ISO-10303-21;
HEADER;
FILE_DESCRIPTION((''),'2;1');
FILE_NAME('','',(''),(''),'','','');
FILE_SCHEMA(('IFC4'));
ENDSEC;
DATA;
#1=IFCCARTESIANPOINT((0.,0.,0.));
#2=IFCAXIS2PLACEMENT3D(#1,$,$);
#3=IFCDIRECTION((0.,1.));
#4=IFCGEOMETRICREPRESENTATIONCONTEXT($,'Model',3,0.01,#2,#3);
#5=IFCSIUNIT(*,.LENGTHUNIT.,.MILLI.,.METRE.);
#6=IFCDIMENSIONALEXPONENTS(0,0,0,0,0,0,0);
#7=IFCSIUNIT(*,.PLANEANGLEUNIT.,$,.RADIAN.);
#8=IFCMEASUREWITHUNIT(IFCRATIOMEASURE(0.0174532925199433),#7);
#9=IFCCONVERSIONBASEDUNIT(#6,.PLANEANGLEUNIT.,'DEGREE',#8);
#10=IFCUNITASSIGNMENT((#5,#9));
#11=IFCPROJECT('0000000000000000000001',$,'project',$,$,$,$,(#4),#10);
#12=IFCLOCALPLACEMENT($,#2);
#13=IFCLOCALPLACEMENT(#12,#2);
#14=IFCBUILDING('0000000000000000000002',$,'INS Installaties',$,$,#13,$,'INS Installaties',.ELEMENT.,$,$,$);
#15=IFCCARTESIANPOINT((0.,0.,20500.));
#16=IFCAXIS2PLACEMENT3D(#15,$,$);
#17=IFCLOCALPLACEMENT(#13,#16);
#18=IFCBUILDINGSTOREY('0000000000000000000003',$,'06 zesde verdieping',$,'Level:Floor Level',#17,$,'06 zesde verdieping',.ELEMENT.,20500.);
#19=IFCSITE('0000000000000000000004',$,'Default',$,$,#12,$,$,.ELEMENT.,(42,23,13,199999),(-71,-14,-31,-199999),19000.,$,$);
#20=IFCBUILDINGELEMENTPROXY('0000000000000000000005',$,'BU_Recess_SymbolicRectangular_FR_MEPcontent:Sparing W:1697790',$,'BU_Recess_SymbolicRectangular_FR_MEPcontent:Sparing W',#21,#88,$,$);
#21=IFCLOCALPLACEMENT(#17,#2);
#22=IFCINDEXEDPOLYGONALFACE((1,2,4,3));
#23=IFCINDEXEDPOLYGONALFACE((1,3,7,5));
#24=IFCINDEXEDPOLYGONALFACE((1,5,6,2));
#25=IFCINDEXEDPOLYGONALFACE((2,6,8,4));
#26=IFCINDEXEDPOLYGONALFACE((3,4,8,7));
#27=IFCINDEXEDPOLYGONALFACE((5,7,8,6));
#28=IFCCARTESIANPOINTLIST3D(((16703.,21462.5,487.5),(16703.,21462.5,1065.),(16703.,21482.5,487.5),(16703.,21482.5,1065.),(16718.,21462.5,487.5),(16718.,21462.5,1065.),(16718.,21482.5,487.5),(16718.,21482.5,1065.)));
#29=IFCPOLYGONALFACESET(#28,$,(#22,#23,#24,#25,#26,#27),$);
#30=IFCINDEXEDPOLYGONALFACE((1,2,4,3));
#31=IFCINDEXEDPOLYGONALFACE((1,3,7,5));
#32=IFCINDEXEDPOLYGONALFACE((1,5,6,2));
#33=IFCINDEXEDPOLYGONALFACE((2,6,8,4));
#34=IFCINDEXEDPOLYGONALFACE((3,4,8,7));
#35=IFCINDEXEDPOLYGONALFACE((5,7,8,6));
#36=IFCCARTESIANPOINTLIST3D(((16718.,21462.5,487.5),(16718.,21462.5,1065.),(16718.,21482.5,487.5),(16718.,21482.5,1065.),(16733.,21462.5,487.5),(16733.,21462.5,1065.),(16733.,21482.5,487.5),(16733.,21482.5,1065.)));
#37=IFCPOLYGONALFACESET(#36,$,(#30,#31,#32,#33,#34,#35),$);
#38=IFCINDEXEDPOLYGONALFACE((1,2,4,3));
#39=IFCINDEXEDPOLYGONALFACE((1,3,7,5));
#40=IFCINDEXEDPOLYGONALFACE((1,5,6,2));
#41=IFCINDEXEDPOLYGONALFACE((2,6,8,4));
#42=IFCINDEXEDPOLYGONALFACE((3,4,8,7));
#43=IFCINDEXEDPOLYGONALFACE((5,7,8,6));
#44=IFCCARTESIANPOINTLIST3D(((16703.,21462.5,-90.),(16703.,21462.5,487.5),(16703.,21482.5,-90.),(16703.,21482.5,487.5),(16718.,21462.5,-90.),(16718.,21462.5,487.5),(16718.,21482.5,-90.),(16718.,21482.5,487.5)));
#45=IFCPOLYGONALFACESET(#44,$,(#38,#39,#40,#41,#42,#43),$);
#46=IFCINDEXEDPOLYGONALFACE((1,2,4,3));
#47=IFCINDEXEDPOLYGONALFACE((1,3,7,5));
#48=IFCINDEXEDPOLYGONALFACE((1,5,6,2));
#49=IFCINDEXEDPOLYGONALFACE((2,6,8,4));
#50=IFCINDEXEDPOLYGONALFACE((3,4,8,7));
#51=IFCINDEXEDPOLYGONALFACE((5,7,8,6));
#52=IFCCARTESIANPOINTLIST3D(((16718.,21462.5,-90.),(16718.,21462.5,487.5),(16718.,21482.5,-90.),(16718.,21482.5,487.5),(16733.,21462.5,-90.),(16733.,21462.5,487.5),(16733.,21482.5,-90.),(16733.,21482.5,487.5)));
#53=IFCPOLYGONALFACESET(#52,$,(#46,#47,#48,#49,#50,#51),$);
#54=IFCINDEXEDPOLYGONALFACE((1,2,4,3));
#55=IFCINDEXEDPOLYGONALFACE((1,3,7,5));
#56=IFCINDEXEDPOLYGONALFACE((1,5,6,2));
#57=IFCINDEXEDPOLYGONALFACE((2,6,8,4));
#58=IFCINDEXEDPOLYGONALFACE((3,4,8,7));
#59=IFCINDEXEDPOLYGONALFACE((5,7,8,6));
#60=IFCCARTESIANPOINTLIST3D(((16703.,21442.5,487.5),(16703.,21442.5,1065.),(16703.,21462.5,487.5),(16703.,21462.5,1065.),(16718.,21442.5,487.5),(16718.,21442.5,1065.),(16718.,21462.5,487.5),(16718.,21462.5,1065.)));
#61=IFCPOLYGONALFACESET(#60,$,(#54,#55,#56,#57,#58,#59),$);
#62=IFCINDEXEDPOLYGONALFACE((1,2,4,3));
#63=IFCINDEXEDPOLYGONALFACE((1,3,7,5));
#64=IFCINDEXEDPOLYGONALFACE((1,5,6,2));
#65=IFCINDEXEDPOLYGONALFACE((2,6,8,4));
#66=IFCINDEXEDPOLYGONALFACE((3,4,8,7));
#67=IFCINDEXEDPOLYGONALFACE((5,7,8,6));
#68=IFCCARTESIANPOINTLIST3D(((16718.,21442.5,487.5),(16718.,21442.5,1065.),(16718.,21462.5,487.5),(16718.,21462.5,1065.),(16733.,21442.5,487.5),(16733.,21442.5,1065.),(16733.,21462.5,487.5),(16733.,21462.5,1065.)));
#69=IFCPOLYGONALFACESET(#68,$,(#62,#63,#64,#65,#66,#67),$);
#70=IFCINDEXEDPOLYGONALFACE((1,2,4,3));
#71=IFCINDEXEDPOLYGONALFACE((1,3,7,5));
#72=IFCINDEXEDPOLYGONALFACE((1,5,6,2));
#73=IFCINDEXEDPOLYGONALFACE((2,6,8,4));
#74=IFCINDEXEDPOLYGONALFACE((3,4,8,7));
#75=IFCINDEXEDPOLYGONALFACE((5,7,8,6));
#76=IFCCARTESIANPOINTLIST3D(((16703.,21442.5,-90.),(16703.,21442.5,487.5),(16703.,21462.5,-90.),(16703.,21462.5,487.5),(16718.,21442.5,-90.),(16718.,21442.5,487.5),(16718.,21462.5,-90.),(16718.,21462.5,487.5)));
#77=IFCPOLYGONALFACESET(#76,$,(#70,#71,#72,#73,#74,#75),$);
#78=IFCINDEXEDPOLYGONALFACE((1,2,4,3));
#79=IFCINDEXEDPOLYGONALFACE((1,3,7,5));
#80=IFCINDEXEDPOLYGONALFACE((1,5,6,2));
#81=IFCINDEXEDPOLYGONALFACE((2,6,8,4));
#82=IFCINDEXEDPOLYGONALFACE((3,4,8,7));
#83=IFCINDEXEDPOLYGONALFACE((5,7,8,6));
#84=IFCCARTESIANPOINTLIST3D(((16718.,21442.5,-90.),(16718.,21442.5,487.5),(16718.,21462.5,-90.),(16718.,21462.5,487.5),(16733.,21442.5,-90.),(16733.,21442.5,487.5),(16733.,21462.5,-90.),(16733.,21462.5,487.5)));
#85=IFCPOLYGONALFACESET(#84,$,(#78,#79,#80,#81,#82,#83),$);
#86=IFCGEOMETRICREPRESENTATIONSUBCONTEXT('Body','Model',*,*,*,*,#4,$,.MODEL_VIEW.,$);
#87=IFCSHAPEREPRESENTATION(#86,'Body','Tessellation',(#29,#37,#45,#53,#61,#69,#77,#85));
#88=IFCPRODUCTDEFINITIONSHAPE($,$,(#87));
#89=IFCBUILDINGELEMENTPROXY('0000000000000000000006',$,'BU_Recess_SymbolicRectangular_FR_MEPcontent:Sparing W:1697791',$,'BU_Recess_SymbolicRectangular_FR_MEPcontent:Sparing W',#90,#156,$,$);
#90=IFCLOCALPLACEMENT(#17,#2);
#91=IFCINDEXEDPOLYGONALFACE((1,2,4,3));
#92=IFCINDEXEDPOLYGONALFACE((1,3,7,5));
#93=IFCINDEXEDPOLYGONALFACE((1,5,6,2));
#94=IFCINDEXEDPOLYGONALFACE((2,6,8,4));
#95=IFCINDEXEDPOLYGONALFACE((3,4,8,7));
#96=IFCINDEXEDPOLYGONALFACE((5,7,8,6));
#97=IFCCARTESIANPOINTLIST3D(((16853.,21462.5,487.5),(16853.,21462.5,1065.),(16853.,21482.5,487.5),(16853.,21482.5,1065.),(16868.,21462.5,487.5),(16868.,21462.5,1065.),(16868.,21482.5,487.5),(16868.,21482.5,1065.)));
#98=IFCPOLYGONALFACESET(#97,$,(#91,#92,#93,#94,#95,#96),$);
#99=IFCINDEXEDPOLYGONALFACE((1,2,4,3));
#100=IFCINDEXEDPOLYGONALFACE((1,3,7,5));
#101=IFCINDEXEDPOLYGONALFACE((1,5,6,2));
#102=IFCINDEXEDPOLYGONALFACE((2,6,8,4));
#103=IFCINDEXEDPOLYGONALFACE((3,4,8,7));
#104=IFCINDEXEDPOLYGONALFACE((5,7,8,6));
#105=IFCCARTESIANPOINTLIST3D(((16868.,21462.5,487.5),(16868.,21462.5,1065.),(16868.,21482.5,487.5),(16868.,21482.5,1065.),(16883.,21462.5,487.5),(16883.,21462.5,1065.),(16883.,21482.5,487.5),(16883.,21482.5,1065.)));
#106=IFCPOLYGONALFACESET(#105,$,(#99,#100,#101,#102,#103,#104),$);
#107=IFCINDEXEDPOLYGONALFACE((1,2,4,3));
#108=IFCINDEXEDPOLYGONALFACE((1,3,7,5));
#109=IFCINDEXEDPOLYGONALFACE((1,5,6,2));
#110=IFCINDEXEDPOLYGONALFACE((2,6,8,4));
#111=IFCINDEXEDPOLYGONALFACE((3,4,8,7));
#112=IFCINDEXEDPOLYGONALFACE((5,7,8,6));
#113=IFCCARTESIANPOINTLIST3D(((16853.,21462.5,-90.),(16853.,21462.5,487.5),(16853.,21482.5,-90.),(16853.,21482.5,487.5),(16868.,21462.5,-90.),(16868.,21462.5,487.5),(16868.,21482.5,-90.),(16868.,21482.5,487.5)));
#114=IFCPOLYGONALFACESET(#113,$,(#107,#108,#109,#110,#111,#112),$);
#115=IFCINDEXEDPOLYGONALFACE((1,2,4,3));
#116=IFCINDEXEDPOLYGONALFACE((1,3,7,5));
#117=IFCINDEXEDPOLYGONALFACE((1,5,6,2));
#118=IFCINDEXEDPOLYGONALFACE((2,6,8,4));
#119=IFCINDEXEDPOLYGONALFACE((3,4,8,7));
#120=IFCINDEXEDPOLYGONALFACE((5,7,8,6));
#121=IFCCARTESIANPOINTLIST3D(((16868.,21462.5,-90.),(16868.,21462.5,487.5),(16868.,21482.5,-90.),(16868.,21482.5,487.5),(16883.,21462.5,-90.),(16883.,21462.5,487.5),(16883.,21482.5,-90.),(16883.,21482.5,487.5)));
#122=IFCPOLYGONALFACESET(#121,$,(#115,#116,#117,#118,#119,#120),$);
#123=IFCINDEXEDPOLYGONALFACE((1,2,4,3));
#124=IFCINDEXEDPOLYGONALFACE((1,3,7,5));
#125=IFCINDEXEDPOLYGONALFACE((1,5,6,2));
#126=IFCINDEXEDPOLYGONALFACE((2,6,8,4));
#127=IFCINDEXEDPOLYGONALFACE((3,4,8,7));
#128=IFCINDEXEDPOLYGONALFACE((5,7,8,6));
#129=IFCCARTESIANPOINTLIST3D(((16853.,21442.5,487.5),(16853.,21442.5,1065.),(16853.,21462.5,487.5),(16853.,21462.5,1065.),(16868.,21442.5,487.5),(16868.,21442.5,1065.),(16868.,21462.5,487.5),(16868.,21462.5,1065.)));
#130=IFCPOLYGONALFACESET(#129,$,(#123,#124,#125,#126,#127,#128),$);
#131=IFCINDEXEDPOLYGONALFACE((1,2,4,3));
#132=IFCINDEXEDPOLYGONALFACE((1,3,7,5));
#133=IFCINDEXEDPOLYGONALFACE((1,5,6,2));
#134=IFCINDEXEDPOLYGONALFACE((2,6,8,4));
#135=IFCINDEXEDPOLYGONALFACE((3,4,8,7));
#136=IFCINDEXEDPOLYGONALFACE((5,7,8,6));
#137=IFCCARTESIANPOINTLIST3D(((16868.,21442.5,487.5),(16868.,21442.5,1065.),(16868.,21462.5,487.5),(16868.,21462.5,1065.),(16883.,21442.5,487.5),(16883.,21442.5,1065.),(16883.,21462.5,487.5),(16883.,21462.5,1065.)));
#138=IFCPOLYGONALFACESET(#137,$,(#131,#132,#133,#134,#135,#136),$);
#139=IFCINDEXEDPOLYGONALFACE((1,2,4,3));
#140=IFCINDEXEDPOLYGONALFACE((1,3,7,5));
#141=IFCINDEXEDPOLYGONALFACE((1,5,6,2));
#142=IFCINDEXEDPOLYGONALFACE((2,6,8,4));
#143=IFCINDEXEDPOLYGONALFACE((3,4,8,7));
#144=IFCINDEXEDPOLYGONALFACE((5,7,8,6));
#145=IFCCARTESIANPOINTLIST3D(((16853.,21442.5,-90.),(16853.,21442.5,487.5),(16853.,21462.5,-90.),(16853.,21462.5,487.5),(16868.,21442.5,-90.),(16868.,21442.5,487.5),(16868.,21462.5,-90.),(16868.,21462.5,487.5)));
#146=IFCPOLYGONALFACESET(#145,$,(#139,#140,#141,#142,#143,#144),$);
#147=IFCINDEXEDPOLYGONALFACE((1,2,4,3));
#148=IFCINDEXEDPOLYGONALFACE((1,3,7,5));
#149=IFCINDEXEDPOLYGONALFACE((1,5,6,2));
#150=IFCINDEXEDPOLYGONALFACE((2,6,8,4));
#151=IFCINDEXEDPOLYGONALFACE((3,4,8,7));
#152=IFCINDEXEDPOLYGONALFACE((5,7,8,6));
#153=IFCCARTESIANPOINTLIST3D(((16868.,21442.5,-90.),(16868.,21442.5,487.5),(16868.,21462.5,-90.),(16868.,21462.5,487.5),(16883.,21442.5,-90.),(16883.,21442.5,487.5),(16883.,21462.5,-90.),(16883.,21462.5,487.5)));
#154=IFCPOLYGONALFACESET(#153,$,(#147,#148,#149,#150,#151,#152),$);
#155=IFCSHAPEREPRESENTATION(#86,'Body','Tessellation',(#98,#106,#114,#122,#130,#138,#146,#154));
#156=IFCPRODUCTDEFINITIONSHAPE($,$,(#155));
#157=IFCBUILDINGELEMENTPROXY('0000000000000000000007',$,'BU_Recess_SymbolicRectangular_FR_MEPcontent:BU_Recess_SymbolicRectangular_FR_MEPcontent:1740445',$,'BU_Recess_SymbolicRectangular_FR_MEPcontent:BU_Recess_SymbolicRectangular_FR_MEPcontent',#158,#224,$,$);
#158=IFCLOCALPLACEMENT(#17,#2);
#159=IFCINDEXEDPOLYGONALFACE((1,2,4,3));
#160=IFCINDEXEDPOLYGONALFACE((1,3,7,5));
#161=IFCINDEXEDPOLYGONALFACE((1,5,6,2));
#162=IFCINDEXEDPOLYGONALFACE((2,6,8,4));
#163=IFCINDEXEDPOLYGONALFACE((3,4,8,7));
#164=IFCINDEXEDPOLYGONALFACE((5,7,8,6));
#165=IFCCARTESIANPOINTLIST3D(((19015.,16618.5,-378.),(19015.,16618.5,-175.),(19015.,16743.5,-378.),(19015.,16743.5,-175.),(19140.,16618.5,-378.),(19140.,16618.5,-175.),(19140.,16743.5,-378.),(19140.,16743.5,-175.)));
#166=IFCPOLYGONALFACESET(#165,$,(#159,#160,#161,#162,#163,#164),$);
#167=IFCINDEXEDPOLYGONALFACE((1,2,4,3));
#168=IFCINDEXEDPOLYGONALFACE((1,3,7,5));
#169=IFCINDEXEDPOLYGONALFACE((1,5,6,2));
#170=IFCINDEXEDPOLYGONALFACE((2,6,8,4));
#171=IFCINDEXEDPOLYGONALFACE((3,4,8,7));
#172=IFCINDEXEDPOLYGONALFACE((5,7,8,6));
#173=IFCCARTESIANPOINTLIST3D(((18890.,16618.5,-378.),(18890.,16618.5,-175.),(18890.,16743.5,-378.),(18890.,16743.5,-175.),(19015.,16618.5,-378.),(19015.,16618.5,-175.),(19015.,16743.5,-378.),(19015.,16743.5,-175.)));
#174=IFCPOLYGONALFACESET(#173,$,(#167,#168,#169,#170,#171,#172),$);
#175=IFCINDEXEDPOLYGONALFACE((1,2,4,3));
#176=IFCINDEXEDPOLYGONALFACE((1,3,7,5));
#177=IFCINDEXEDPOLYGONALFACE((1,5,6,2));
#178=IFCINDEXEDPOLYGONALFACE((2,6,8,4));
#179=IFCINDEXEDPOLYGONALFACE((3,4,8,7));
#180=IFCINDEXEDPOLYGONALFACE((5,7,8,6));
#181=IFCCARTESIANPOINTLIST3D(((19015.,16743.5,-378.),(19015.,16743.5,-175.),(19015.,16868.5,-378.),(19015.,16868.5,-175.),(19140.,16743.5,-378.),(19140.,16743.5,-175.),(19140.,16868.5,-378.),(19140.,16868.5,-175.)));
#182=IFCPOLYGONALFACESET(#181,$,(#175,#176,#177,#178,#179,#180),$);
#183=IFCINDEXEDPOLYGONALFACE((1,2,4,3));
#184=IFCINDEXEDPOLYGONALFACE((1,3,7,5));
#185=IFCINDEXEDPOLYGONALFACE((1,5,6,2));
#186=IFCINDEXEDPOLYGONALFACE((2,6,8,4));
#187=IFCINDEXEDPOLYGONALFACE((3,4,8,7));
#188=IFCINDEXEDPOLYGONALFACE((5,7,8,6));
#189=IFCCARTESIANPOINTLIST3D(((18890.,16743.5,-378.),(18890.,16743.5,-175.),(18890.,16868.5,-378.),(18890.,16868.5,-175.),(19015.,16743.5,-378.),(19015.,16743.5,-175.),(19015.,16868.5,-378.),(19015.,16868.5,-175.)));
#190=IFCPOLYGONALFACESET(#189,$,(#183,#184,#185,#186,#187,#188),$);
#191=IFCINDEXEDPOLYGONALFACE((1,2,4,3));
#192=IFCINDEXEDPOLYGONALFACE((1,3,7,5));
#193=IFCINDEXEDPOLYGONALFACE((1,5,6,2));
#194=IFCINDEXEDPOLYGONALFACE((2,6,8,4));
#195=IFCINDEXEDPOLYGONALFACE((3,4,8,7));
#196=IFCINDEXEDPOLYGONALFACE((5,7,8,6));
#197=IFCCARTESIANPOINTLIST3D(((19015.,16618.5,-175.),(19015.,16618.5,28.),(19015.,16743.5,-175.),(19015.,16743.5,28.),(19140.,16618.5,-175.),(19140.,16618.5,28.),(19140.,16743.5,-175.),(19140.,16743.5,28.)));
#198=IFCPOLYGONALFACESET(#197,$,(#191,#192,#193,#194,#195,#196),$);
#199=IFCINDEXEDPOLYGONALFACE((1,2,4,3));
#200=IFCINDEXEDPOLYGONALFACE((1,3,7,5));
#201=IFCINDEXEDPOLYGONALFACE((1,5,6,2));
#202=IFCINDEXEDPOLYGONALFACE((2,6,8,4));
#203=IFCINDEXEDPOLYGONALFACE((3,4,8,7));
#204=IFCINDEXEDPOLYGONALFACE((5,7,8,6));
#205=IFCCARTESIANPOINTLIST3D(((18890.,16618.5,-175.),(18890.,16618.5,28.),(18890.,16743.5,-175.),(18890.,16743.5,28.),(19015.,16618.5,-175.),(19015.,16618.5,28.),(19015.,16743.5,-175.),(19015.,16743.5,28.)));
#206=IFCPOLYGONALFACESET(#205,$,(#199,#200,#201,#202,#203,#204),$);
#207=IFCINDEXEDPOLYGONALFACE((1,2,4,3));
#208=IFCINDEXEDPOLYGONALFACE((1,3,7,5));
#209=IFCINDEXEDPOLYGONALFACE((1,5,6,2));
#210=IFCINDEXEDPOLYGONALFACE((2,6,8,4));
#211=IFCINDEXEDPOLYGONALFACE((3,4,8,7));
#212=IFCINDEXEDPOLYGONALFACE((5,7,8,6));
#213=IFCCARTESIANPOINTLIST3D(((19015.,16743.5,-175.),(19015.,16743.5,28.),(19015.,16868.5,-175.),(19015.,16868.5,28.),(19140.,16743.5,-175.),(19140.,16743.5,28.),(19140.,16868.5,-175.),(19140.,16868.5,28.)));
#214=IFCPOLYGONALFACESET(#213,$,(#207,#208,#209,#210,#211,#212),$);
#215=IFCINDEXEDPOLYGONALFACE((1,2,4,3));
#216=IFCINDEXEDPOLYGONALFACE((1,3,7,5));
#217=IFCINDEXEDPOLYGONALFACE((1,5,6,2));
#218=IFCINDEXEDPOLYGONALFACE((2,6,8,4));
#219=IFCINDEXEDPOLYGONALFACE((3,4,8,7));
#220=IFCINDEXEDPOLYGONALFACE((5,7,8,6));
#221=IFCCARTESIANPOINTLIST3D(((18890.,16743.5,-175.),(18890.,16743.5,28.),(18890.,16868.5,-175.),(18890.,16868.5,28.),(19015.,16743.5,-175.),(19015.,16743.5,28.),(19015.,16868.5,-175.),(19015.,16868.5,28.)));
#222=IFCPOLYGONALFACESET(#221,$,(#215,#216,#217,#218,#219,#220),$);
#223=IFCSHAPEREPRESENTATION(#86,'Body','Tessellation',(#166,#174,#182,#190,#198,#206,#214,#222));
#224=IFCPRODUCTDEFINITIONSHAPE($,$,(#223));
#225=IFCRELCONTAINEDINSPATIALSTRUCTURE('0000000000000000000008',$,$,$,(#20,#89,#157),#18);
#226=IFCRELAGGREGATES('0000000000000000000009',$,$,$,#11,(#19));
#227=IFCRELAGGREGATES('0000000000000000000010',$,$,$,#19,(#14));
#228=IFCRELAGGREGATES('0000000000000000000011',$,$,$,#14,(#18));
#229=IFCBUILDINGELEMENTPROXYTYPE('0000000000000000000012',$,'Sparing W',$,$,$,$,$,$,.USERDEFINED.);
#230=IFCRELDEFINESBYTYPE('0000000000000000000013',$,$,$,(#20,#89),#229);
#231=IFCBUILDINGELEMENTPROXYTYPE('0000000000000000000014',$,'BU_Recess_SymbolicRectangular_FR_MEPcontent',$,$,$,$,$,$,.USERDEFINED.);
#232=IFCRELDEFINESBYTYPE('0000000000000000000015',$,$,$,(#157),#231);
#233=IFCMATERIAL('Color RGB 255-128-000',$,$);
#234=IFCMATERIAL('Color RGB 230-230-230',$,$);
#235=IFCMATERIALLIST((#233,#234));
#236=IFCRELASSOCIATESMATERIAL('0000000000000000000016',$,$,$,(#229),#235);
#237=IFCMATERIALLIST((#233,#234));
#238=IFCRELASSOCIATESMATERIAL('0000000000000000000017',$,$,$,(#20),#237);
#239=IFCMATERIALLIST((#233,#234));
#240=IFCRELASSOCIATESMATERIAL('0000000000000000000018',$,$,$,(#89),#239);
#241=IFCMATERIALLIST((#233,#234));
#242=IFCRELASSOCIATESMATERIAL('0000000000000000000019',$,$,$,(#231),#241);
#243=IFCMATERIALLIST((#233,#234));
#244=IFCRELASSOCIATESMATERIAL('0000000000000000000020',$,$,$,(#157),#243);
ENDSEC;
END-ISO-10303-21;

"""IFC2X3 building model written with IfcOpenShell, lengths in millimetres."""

from ifc_helpers import new_model, entity, si_unit, converted_unit, direction, frame, frame_2d, origin, origin_2d_with_axis, place, context, subcontext, project, spatial, rectangle, extrude, source, transform, mapped, material, material_list, type_object, type_shapes, element, save


model = new_model("IFC2X3")

# Units and contexts
model_context = context("Model", 3, precision=0.01, world=origin(), true_north=direction((0.0, 1.0)))
body_context = subcontext(model_context, "Body", "Model", "MODEL_VIEW")
ifc_project = project(units=[si_unit("LENGTHUNIT", "METRE", prefix="MILLI"), converted_unit("PLANEANGLEUNIT", "DEGREE", entity("IfcRatioMeasure", 0.0174532925199433), si_unit("PLANEANGLEUNIT", "RADIAN"), dimensions=[0, 0, 0, 0, 0, 0, 0])], contexts=[model_context])

# Site, building, storey
site_placement = place(None, origin())
site = spatial("IfcSite", under=ifc_project, at=site_placement, Name="Default", CompositionType="ELEMENT", RefLatitude=(42, 23, 13, 199999), RefLongitude=(-71, -14, -31, -199999), RefElevation=19000.0)
building_placement = place(site_placement, origin())
building = spatial("IfcBuilding", under=site, at=building_placement, Name="INS Installaties", LongName="INS Installaties", CompositionType="ELEMENT")
storey_placement = place(building_placement, frame((0.0, 0.0, 20500.0)))
storey = spatial("IfcBuildingStorey", under=building, at=storey_placement, Name="06 zesde verdieping", ObjectType="Level:Floor Level", LongName="06 zesde verdieping", CompositionType="ELEMENT", Elevation=20500.0)

# Building element proxies
ifc_material_1 = material(Name="Color RGB 255-128-000")
ifc_material_2 = material(Name="Color RGB 230-230-230")
ifc_material_list_1 = material_list([ifc_material_1, ifc_material_2])
ifc_material_list_2 = material_list([ifc_material_1, ifc_material_2])
building_element_proxy_type_1 = type_object("IfcBuildingElementProxyType", Name="Sparing W", PredefinedType="USERDEFINED", material=ifc_material_list_2)
shared_shape_1 = source(origin(), body_context, "Body", "SweptSolid", [
    extrude(rectangle(XDim=20.0, YDim=15.0, at=frame_2d((0.0, 0.0), x_axis=(1.0, 0.0))), frame((7.5, -27.0, 0.0), z_axis=(0.0, 0.0, 1.0), x_axis=(0.0, -1.0, 0.0)), (0.0, 0.0, 1.0), 577.5),
    extrude(rectangle(XDim=20.0, YDim=15.0, at=frame_2d((0.0, 0.0), x_axis=(1.0, 0.0))), frame((-7.5, -27.0, 0.0), z_axis=(0.0, 0.0, 1.0), x_axis=(0.0, -1.0, 0.0)), (0.0, 0.0, 1.0), 577.5),
    extrude(rectangle(XDim=20.0, YDim=15.0, at=frame_2d((0.0, 0.0), x_axis=(1.0, 0.0))), frame((7.5, -27.0, -577.5), z_axis=(0.0, 0.0, 1.0), x_axis=(0.0, -1.0, 0.0)), (0.0, 0.0, 1.0), 577.5),
    extrude(rectangle(XDim=20.0, YDim=15.0, at=frame_2d((0.0, 0.0), x_axis=(1.0, 0.0))), frame((-7.5, -27.0, -577.5), z_axis=(0.0, 0.0, 1.0), x_axis=(0.0, -1.0, 0.0)), (0.0, 0.0, 1.0), 577.5),
    extrude(rectangle(XDim=20.0, YDim=15.0, at=frame_2d((0.0, 0.0), x_axis=(1.0, 0.0))), frame((7.5, -7.0, 0.0), z_axis=(0.0, 0.0, 1.0), x_axis=(0.0, -1.0, 0.0)), (0.0, 0.0, 1.0), 577.5),
    extrude(rectangle(XDim=20.0, YDim=15.0, at=frame_2d((0.0, 0.0), x_axis=(1.0, 0.0))), frame((-7.5, -7.0, 0.0), z_axis=(0.0, 0.0, 1.0), x_axis=(0.0, -1.0, 0.0)), (0.0, 0.0, 1.0), 577.5),
    extrude(rectangle(XDim=20.0, YDim=15.0, at=origin_2d_with_axis()), frame((7.5, -7.0, -577.5), z_axis=(0.0, 0.0, 1.0), x_axis=(0.0, -1.0, 0.0)), (0.0, 0.0, 1.0), 577.5),
    extrude(rectangle(XDim=20.0, YDim=15.0, at=frame_2d((0.0, 0.0), x_axis=(1.0, 0.0))), frame((-7.5, -7.0, -577.5), z_axis=(0.0, 0.0, 1.0), x_axis=(0.0, -1.0, 0.0)), (0.0, 0.0, 1.0), 577.5),
])
type_shapes(building_element_proxy_type_1, [shared_shape_1])
proxy_1_placement = place(storey_placement, frame((16718.0, 21445.5, 487.5), z_axis=(0.0, 0.0, 1.0), x_axis=(-1.0, 0.0, 0.0)))
element("IfcBuildingElementProxy", 1, at=proxy_1_placement, inside=storey, type_object=building_element_proxy_type_1, material=ifc_material_list_1, Name="BU_Recess_SymbolicRectangular_FR_MEPcontent:Sparing W:1697790", ObjectType="BU_Recess_SymbolicRectangular_FR_MEPcontent:Sparing W", context=body_context, shape_type="MappedRepresentation", body=[
    mapped(shared_shape_1, transform((0.0, 0.0, 0.0), scale=1.0)),
])
ifc_material_list_3 = material_list([ifc_material_1, ifc_material_2])
proxy_2_placement = place(storey_placement, frame((16868.0, 21445.5, 487.5), z_axis=(0.0, 0.0, 1.0), x_axis=(-1.0, 0.0, 0.0)))
element("IfcBuildingElementProxy", 2, at=proxy_2_placement, inside=storey, type_object=building_element_proxy_type_1, material=ifc_material_list_3, Name="BU_Recess_SymbolicRectangular_FR_MEPcontent:Sparing W:1697791", ObjectType="BU_Recess_SymbolicRectangular_FR_MEPcontent:Sparing W", context=body_context, shape_type="MappedRepresentation", body=[
    mapped(shared_shape_1, transform((0.0, 0.0, 0.0), scale=1.0)),
])
ifc_material_list_4 = material_list([ifc_material_1, ifc_material_2])
ifc_material_list_5 = material_list([ifc_material_1, ifc_material_2])
building_element_proxy_type_2 = type_object("IfcBuildingElementProxyType", Name="BU_Recess_SymbolicRectangular_FR_MEPcontent", PredefinedType="USERDEFINED", material=ifc_material_list_5)
shared_shape_2 = source(origin(), body_context, "Body", "SweptSolid", [
    extrude(rectangle(XDim=125.0, YDim=125.0, at=frame_2d((0.0, 0.0), x_axis=(1.0, 0.0))), frame((62.5, -62.5, -403.0)), (0.0, 0.0, 1.0), 203.0),
    extrude(rectangle(XDim=125.0, YDim=125.0, at=origin_2d_with_axis()), frame((-62.5, -62.5, -403.0), z_axis=(0.0, 0.0, 1.0), x_axis=(0.0, 1.0, 0.0)), (0.0, 0.0, 1.0), 203.0),
    extrude(rectangle(XDim=125.0, YDim=125.0, at=origin_2d_with_axis()), frame((62.5, 62.5, -403.0), z_axis=(0.0, 0.0, 1.0), x_axis=(0.0, -1.0, 0.0)), (0.0, 0.0, 1.0), 203.0),
    extrude(rectangle(XDim=125.0, YDim=125.0, at=origin_2d_with_axis()), frame((-62.5, 62.5, -403.0), z_axis=(0.0, 0.0, 1.0), x_axis=(-1.0, 0.0, 0.0)), (0.0, 0.0, 1.0), 203.0),
    extrude(rectangle(XDim=125.0, YDim=125.0, at=frame_2d((0.0, 0.0), x_axis=(1.0, 0.0))), frame((62.5, -62.5, -200.0)), (0.0, 0.0, 1.0), 203.0),
    extrude(rectangle(XDim=125.0, YDim=125.0, at=frame_2d((0.0, 0.0), x_axis=(1.0, 0.0))), frame((-62.5, -62.5, -200.0), z_axis=(0.0, 0.0, 1.0), x_axis=(0.0, 1.0, 0.0)), (0.0, 0.0, 1.0), 203.0),
    extrude(rectangle(XDim=125.0, YDim=125.0, at=frame_2d((0.0, 0.0), x_axis=(1.0, 0.0))), frame((62.5, 62.5, -200.0), z_axis=(0.0, 0.0, 1.0), x_axis=(0.0, -1.0, 0.0)), (0.0, 0.0, 1.0), 203.0),
    extrude(rectangle(XDim=125.0, YDim=125.0, at=origin_2d_with_axis()), frame((-62.5, 62.5, -200.0), z_axis=(0.0, 0.0, 1.0), x_axis=(-1.0, 0.0, 0.0)), (0.0, 0.0, 1.0), 203.0),
])
type_shapes(building_element_proxy_type_2, [shared_shape_2])
proxy_3_placement = place(storey_placement, frame((19015.0, 16743.5, 25.0)))
element("IfcBuildingElementProxy", 3, at=proxy_3_placement, inside=storey, type_object=building_element_proxy_type_2, material=ifc_material_list_4, Name="BU_Recess_SymbolicRectangular_FR_MEPcontent:BU_Recess_SymbolicRectangular_FR_MEPcontent:1740445", ObjectType="BU_Recess_SymbolicRectangular_FR_MEPcontent:BU_Recess_SymbolicRectangular_FR_MEPcontent", context=body_context, shape_type="MappedRepresentation", body=[
    mapped(shared_shape_2, transform((0.0, 0.0, 0.0), scale=1.0)),
])

save(model, "model.ifc")
